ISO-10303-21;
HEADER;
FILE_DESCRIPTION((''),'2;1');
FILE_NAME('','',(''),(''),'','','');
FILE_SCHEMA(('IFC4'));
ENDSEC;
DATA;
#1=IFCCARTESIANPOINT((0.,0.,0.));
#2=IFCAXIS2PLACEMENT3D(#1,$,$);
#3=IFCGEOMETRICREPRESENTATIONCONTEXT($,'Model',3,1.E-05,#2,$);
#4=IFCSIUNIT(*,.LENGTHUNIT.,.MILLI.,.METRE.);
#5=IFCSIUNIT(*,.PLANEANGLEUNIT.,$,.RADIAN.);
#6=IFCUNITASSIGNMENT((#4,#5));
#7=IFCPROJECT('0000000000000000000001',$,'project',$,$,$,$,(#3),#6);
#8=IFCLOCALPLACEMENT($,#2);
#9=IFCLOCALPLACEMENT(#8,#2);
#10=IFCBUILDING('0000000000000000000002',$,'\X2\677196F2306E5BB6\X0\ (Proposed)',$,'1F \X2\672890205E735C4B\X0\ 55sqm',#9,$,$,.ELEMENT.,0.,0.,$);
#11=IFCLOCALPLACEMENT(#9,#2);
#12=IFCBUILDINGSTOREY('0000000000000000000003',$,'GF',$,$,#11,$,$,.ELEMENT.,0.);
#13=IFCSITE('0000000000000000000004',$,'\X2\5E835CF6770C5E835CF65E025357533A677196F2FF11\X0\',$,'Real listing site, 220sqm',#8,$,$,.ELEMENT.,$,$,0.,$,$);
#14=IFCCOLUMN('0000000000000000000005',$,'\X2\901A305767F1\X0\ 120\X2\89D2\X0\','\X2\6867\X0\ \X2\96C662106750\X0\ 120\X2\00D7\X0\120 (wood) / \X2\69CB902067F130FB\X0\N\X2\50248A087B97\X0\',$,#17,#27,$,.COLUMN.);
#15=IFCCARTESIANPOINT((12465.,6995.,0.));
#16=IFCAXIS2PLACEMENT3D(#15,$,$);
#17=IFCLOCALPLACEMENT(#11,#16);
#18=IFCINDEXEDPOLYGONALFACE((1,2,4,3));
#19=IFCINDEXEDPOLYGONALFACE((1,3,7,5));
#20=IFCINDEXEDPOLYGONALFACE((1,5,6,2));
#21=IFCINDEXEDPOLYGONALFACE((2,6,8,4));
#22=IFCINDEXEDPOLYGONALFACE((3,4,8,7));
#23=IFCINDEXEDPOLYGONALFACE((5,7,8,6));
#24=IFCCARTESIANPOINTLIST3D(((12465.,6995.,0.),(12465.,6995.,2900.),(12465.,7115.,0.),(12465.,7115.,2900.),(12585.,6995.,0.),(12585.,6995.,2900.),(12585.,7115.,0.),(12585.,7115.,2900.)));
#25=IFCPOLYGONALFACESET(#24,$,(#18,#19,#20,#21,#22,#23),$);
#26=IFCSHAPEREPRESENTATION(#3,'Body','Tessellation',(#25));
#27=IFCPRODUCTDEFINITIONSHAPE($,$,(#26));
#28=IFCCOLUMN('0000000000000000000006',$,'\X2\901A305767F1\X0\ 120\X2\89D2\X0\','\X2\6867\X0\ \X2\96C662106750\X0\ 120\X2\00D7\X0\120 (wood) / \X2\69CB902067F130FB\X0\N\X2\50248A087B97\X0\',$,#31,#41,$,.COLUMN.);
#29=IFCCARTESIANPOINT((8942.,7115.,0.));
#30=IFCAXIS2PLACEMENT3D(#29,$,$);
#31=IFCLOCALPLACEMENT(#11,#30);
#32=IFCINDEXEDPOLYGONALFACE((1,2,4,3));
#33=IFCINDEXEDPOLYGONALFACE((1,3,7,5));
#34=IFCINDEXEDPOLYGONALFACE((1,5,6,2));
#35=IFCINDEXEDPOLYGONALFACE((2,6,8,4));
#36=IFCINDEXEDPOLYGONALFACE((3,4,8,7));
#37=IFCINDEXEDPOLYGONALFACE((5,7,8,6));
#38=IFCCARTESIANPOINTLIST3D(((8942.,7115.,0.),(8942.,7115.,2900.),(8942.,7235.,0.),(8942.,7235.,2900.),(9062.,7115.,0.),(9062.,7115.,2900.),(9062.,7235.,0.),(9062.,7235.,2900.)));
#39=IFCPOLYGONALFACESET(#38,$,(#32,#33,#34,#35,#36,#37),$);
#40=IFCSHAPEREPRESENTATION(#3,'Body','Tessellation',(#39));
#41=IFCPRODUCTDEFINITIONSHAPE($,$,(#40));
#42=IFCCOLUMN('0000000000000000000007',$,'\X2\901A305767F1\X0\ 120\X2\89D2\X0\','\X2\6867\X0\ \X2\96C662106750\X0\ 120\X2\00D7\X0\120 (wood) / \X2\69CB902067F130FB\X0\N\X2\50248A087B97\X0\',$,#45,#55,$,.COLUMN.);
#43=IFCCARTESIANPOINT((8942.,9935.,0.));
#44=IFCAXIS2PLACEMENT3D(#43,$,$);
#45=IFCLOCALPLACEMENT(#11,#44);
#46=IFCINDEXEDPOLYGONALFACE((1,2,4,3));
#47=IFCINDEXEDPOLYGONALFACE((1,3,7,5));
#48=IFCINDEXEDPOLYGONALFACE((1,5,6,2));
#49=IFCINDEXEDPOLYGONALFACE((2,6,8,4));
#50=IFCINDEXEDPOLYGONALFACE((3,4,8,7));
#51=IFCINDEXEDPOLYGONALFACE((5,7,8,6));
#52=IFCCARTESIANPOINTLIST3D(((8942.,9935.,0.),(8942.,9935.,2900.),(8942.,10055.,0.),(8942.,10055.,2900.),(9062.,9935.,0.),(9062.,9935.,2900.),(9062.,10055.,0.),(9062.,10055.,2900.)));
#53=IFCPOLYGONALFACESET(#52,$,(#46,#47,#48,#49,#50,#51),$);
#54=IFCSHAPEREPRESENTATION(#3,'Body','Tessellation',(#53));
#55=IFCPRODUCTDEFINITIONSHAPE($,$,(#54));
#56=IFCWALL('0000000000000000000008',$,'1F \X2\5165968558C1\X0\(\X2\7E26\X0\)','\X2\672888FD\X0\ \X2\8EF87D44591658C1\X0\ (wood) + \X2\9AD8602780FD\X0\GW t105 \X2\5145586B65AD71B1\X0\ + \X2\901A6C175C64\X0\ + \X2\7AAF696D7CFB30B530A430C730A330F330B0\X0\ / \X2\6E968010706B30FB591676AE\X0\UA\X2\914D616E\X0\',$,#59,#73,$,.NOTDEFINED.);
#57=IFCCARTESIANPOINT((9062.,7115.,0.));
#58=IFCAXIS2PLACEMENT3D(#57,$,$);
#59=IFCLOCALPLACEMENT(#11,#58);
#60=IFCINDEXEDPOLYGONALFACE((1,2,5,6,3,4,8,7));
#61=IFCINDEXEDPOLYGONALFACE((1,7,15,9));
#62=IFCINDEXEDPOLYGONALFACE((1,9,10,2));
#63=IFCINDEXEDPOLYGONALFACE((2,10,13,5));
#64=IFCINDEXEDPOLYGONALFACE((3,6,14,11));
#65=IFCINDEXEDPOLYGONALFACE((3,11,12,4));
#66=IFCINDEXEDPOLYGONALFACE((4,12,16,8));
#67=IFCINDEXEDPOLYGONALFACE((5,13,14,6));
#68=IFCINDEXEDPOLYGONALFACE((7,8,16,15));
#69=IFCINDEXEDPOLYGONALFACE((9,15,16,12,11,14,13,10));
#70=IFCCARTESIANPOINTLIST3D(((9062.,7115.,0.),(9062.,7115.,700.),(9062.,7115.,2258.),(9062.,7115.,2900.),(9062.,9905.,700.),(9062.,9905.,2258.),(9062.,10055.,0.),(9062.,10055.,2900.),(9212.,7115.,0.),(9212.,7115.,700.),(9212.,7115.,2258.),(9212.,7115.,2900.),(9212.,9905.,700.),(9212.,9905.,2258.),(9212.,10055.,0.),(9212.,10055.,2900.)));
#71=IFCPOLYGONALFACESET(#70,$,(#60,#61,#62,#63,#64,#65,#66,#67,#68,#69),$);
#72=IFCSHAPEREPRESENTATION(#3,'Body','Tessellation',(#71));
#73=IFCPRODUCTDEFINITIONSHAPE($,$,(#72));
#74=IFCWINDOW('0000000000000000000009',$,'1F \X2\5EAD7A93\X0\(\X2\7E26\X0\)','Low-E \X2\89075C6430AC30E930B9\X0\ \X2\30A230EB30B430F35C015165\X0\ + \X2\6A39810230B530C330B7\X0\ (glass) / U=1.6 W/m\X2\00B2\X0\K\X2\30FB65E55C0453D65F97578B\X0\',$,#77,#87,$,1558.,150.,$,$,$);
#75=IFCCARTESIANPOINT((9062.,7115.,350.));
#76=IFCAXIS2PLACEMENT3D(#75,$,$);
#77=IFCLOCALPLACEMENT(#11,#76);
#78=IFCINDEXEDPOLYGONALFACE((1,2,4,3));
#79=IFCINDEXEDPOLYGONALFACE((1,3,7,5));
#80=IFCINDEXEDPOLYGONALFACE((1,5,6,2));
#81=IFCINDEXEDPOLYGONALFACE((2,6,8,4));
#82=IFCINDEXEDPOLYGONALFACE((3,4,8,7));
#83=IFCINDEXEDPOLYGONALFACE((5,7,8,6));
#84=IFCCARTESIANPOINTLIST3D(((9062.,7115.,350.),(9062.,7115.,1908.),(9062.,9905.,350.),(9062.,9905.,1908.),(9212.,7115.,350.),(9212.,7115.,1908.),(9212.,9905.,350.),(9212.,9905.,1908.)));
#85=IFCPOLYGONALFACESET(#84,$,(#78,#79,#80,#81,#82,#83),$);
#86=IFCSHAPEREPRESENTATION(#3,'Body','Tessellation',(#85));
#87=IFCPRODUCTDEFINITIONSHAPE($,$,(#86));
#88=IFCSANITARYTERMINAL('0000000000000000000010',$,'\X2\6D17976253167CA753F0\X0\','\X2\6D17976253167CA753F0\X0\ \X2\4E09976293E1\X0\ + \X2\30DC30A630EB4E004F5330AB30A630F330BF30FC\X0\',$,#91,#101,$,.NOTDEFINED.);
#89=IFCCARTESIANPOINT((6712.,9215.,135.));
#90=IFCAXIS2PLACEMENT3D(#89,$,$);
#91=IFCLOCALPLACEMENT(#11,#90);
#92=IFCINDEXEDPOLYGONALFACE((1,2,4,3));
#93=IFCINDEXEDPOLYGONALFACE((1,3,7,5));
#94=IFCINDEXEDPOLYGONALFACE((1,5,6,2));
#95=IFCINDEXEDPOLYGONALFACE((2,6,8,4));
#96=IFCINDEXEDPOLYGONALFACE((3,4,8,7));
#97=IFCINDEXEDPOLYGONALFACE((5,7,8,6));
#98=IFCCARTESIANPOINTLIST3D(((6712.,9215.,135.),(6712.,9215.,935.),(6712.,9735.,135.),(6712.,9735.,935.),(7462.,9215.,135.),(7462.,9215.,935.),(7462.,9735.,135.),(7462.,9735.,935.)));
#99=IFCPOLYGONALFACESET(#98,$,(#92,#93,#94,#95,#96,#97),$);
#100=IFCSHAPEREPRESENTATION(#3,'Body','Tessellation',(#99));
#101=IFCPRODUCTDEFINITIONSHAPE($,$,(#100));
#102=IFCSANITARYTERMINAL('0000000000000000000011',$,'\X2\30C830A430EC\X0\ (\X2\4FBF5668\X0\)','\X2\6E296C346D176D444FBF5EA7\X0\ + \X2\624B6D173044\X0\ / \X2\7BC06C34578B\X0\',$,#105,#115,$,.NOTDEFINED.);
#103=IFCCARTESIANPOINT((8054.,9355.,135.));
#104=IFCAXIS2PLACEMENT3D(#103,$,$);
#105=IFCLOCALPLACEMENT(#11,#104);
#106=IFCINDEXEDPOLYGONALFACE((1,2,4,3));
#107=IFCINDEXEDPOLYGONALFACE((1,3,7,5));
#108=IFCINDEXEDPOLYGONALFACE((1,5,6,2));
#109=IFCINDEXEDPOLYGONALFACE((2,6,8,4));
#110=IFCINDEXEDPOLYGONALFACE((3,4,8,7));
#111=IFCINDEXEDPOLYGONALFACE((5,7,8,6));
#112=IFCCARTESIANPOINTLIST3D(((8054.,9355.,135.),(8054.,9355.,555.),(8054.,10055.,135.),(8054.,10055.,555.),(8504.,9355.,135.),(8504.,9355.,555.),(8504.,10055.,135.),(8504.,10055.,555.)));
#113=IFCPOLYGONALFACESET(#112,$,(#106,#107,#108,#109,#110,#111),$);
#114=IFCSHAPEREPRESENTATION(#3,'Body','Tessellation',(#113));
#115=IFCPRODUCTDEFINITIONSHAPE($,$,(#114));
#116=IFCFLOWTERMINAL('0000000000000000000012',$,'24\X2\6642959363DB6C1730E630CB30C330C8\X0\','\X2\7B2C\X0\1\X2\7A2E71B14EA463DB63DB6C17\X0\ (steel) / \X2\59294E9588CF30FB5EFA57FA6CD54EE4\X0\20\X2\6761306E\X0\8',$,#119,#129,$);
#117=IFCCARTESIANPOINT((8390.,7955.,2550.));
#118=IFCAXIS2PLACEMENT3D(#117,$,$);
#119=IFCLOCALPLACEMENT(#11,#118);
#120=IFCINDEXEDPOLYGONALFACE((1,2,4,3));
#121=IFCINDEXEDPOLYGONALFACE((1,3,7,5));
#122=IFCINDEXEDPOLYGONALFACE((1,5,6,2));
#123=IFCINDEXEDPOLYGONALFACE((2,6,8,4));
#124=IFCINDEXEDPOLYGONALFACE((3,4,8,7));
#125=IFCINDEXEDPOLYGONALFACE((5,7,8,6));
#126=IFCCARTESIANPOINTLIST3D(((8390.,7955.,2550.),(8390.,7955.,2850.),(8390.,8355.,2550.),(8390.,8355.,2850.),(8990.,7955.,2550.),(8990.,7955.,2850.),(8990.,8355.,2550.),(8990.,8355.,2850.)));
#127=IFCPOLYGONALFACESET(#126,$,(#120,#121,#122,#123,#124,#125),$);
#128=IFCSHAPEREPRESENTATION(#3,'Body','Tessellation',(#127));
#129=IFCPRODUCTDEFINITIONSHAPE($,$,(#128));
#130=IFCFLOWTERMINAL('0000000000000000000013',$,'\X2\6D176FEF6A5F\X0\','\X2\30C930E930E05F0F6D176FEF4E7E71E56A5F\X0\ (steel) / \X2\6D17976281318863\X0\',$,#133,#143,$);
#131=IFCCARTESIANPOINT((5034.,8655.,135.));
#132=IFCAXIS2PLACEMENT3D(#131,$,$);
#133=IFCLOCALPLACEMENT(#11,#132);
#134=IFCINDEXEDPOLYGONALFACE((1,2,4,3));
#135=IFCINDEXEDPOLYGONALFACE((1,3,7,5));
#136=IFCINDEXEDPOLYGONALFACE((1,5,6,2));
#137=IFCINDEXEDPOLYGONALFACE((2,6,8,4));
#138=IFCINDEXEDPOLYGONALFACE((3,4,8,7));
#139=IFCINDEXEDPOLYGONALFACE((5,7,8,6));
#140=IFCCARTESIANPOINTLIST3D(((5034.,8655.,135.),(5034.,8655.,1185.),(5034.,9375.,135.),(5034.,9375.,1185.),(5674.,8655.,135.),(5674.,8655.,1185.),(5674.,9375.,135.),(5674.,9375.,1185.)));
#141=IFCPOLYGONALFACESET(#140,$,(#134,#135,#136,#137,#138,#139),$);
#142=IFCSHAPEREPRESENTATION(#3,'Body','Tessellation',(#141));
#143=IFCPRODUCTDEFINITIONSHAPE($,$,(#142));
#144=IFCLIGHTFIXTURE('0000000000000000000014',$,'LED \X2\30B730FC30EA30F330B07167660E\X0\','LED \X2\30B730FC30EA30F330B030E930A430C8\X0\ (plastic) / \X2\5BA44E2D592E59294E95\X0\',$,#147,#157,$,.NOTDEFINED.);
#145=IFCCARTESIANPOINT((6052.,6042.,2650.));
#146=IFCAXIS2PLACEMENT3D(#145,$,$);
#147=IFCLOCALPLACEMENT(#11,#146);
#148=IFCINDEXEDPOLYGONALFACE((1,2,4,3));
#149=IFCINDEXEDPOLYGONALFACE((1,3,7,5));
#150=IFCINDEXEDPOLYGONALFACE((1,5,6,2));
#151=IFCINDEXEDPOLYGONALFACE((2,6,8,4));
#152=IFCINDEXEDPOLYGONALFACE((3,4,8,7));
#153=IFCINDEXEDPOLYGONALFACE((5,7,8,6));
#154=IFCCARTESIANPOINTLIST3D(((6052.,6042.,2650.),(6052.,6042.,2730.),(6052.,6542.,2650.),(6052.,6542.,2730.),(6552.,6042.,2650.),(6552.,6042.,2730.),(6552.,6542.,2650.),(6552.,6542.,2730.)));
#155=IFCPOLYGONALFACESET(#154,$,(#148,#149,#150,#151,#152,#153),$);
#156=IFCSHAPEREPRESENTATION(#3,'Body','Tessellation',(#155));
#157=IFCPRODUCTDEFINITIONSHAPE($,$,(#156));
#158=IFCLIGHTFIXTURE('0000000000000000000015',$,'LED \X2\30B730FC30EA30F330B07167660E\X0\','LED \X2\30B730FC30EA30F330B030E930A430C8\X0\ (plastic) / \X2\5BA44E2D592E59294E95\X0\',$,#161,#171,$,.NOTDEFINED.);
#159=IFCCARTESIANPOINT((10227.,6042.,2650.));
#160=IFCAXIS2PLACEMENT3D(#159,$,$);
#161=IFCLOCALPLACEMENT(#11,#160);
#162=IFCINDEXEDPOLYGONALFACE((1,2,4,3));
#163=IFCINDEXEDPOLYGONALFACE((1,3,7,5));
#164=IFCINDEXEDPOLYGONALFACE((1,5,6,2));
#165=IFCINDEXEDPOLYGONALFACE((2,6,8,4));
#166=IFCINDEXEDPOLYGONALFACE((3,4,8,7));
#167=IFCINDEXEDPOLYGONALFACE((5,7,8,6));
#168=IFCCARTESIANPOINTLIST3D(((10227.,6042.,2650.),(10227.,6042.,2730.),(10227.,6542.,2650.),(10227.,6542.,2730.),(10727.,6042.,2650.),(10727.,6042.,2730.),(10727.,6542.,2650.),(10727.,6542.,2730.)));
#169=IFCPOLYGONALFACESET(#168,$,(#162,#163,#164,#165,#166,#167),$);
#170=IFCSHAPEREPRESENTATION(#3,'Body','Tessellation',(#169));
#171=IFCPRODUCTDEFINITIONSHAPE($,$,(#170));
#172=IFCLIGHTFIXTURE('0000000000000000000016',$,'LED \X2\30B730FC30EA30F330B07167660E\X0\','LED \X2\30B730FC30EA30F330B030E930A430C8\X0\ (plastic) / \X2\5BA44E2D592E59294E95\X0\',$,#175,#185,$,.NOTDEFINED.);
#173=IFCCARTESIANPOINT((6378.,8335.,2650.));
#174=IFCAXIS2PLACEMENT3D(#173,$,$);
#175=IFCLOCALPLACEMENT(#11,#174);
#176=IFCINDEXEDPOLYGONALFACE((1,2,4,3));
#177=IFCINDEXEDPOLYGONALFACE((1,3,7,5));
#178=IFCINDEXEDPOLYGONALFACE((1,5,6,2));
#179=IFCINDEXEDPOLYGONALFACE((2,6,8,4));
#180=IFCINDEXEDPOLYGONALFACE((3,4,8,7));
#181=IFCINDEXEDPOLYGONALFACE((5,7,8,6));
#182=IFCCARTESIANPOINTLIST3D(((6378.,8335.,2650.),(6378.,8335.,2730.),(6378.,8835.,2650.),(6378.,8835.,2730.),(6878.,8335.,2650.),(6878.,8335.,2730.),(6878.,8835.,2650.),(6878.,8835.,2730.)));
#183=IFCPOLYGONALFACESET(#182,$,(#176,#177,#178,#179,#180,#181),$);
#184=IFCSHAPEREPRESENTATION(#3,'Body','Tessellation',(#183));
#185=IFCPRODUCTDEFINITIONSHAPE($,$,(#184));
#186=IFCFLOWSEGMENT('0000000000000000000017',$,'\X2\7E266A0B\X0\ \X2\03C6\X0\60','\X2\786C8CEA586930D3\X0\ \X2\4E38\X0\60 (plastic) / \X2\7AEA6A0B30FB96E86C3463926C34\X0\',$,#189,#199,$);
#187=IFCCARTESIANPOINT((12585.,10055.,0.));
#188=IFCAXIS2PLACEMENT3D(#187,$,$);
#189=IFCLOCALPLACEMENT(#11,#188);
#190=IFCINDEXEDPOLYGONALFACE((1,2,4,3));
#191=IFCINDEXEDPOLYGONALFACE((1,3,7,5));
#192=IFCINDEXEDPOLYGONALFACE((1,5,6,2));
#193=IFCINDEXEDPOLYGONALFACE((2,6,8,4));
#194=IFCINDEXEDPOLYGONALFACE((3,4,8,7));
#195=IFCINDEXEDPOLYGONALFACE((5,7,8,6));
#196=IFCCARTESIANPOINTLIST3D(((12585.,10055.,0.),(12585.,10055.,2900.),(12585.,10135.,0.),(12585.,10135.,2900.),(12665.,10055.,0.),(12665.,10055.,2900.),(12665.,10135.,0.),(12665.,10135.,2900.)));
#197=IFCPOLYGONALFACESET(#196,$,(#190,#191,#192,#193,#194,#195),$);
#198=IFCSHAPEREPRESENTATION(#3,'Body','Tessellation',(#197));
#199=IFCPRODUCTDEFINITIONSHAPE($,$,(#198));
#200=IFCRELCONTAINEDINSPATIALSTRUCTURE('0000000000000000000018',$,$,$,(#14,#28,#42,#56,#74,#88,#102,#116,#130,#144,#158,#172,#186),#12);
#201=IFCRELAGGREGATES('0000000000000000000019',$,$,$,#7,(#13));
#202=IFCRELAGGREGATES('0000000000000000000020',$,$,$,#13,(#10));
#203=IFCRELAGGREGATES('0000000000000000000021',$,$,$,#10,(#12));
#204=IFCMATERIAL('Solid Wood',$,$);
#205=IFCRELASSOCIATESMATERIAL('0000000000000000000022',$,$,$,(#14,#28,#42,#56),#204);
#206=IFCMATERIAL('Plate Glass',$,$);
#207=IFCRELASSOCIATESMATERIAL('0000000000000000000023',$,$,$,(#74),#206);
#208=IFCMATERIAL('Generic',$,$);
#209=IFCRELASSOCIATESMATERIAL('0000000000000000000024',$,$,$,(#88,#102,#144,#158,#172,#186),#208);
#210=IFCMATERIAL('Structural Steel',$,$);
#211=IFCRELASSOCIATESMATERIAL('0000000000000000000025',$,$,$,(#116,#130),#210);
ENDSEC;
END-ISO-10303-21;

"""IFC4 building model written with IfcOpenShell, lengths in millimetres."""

from ifc_helpers import new_model, si_unit, frame, frame_2d, origin, place, context, project, spatial, rectangle, extrude, material, element, fill, save


model = new_model("IFC4")

# Units and contexts
model_context = context("Model", 3, precision=1e-05, world=origin())
ifc_project = project(units=[si_unit("LENGTHUNIT", "METRE", prefix="MILLI"), si_unit("PLANEANGLEUNIT", "RADIAN")], contexts=[model_context])

# Site, building, storey
site_placement = place(None, origin())
site = spatial("IfcSite", under=ifc_project, at=site_placement, Name="広島県広島市南区東雲１", ObjectType="Real listing site, 220sqm", CompositionType="ELEMENT", RefElevation=0.0)
building_placement = place(site_placement, origin())
building = spatial("IfcBuilding", under=site, at=building_placement, Name="東雲の家 (Proposed)", ObjectType="1F 木造平屋 55sqm", CompositionType="ELEMENT", ElevationOfRefHeight=0.0, ElevationOfTerrain=0.0)
storey_placement = place(building_placement, origin())
storey = spatial("IfcBuildingStorey", under=building, at=storey_placement, Name="GF", CompositionType="ELEMENT", Elevation=0.0)

# Columns
ifc_material_1 = material(Name="Solid Wood")
column_1_placement = place(storey_placement, frame((12465.0, 6995.0, 0.0)))
element("IfcColumn", 1, at=column_1_placement, inside=storey, material=ifc_material_1, Name="通し柱 120角", Description="桧 集成材 120×120 (wood) / 構造柱・N値計算", PredefinedType="COLUMN", context=model_context, shape_type="SweptSolid", body=[
    extrude(rectangle(XDim=120.0, YDim=120.0, at=frame_2d((60.0, 60.0))), frame((12465.0, 6995.0, 0.0)), (0.0, 0.0, 1.0), 2900.0),
])
column_2_placement = place(storey_placement, frame((8942.0, 7115.0, 0.0)))
element("IfcColumn", 2, at=column_2_placement, inside=storey, material=ifc_material_1, Name="通し柱 120角", Description="桧 集成材 120×120 (wood) / 構造柱・N値計算", PredefinedType="COLUMN", context=model_context, shape_type="SweptSolid", body=[
    extrude(rectangle(XDim=120.0, YDim=120.0, at=frame_2d((60.0, 60.0))), frame((8942.0, 7115.0, 0.0)), (0.0, 0.0, 1.0), 2900.0),
])
column_3_placement = place(storey_placement, frame((8942.0, 9935.0, 0.0)))
element("IfcColumn", 3, at=column_3_placement, inside=storey, material=ifc_material_1, Name="通し柱 120角", Description="桧 集成材 120×120 (wood) / 構造柱・N値計算", PredefinedType="COLUMN", context=model_context, shape_type="SweptSolid", body=[
    extrude(rectangle(XDim=120.0, YDim=120.0, at=frame_2d((60.0, 60.0))), frame((8942.0, 9935.0, 0.0)), (0.0, 0.0, 1.0), 2900.0),
])

# Wall, opening, window
wall_1_placement = place(storey_placement, frame((9062.0, 7115.0, 0.0)))
wall_1 = element("IfcWall", 4, at=wall_1_placement, inside=storey, material=ifc_material_1, Name="1F 入隅壁(縦)", Description="木製 軸組外壁 (wood) + 高性能GW t105 充填断熱 + 通気層 + 窯業系サイディング / 準耐火・外皮UA配慮", PredefinedType="NOTDEFINED", context=model_context, shape_type="SweptSolid", body=[
    extrude(rectangle(XDim=150.0, YDim=2940.0, at=frame_2d((75.0, 1470.0))), frame((9062.0, 7115.0, 0.0)), (0.0, 0.0, 1.0), 2900.0),
])
opening_placement = place(storey_placement, frame((9062.0, 7115.0, 350.0)))
opening = element("IfcOpeningElement", 5, at=opening_placement, cuts=wall_1, PredefinedType="NOTDEFINED", context=model_context, shape_type="SweptSolid", body=[
    extrude(rectangle(XDim=150.0, YDim=2790.0, at=frame_2d((75.0, 1395.0))), frame((9062.0, 7115.0, 350.0)), (0.0, 0.0, 1.0), 1558.0),
])
ifc_material_2 = material(Name="Plate Glass")
window_placement = place(storey_placement, frame((9062.0, 7115.0, 350.0)))
window = element("IfcWindow", 6, at=window_placement, inside=storey, material=ifc_material_2, Name="1F 庭窓(縦)", Description="Low-E 複層ガラス アルゴン封入 + 樹脂サッシ (glass) / U=1.6 W/m²K・日射取得型", OverallHeight=1558.0, OverallWidth=150.0, context=model_context, shape_type="SweptSolid", body=[
    extrude(rectangle(XDim=150.0, YDim=2790.0, at=frame_2d((75.0, 1395.0))), frame((9062.0, 7115.0, 350.0)), (0.0, 0.0, 1.0), 1558.0),
])
fill(opening, window)

# Sanitary terminals
ifc_material_3 = material(Name="Generic")
sanitary_terminal_1_placement = place(storey_placement, frame((6712.0, 9215.0, 135.0)))
element("IfcSanitaryTerminal", 7, at=sanitary_terminal_1_placement, inside=storey, material=ifc_material_3, Name="洗面化粧台", Description="洗面化粧台 三面鏡 + ボウル一体カウンター", PredefinedType="NOTDEFINED", context=model_context, shape_type="SweptSolid", body=[
    extrude(rectangle(XDim=750.0, YDim=520.0, at=frame_2d((375.0, 260.0))), frame((6712.0, 9215.0, 135.0)), (0.0, 0.0, 1.0), 800.0),
])
sanitary_terminal_2_placement = place(storey_placement, frame((8054.0, 9355.0, 135.0)))
element("IfcSanitaryTerminal", 8, at=sanitary_terminal_2_placement, inside=storey, material=ifc_material_3, Name="トイレ (便器)", Description="温水洗浄便座 + 手洗い / 節水型", PredefinedType="NOTDEFINED", context=model_context, shape_type="SweptSolid", body=[
    extrude(rectangle(XDim=450.0, YDim=700.0, at=frame_2d((225.0, 350.0))), frame((8054.0, 9355.0, 135.0)), (0.0, 0.0, 1.0), 420.0),
])

# Flow terminals
ifc_material_4 = material(Name="Structural Steel")
flow_terminal_1_placement = place(storey_placement, frame((8390.0, 7955.0, 2550.0)))
element("IfcFlowTerminal", 9, at=flow_terminal_1_placement, inside=storey, material=ifc_material_4, Name="24時間換気ユニット", Description="第1種熱交換換気 (steel) / 天井裏・建基法令20条の8", context=model_context, shape_type="SweptSolid", body=[
    extrude(rectangle(XDim=600.0, YDim=400.0, at=frame_2d((300.0, 200.0))), frame((8390.0, 7955.0, 2550.0)), (0.0, 0.0, 1.0), 300.0),
])
flow_terminal_2_placement = place(storey_placement, frame((5034.0, 8655.0, 135.0)))
element("IfcFlowTerminal", 10, at=flow_terminal_2_placement, inside=storey, material=ifc_material_4, Name="洗濯機", Description="ドラム式洗濯乾燥機 (steel) / 洗面脱衣", context=model_context, shape_type="SweptSolid", body=[
    extrude(rectangle(XDim=640.0, YDim=720.0, at=frame_2d((320.0, 360.0))), frame((5034.0, 8655.0, 135.0)), (0.0, 0.0, 1.0), 1050.0),
])

# Light fixtures
light_fixture_1_placement = place(storey_placement, frame((6052.0, 6042.0, 2650.0)))
element("IfcLightFixture", 11, at=light_fixture_1_placement, inside=storey, material=ifc_material_3, Name="LED シーリング照明", Description="LED シーリングライト (plastic) / 室中央天井", PredefinedType="NOTDEFINED", context=model_context, shape_type="SweptSolid", body=[
    extrude(rectangle(XDim=500.0, YDim=500.0, at=frame_2d((250.0, 250.0))), frame((6052.0, 6042.0, 2650.0)), (0.0, 0.0, 1.0), 80.0),
])
light_fixture_2_placement = place(storey_placement, frame((10227.0, 6042.0, 2650.0)))
element("IfcLightFixture", 12, at=light_fixture_2_placement, inside=storey, material=ifc_material_3, Name="LED シーリング照明", Description="LED シーリングライト (plastic) / 室中央天井", PredefinedType="NOTDEFINED", context=model_context, shape_type="SweptSolid", body=[
    extrude(rectangle(XDim=500.0, YDim=500.0, at=frame_2d((250.0, 250.0))), frame((10227.0, 6042.0, 2650.0)), (0.0, 0.0, 1.0), 80.0),
])
light_fixture_3_placement = place(storey_placement, frame((6378.0, 8335.0, 2650.0)))
element("IfcLightFixture", 13, at=light_fixture_3_placement, inside=storey, material=ifc_material_3, Name="LED シーリング照明", Description="LED シーリングライト (plastic) / 室中央天井", PredefinedType="NOTDEFINED", context=model_context, shape_type="SweptSolid", body=[
    extrude(rectangle(XDim=500.0, YDim=500.0, at=frame_2d((250.0, 250.0))), frame((6378.0, 8335.0, 2650.0)), (0.0, 0.0, 1.0), 80.0),
])

# Flow segment
flow_segment_placement = place(storey_placement, frame((12585.0, 10055.0, 0.0)))
element("IfcFlowSegment", 14, at=flow_segment_placement, inside=storey, material=ifc_material_3, Name="縦樋 φ60", Description="硬質塩ビ 丸60 (plastic) / 竪樋・雨水排水", context=model_context, shape_type="SweptSolid", body=[
    extrude(rectangle(XDim=80.0, YDim=80.0, at=frame_2d((40.0, 40.0))), frame((12585.0, 10055.0, 0.0)), (0.0, 0.0, 1.0), 2900.0),
])

save(model, "model.ifc")
